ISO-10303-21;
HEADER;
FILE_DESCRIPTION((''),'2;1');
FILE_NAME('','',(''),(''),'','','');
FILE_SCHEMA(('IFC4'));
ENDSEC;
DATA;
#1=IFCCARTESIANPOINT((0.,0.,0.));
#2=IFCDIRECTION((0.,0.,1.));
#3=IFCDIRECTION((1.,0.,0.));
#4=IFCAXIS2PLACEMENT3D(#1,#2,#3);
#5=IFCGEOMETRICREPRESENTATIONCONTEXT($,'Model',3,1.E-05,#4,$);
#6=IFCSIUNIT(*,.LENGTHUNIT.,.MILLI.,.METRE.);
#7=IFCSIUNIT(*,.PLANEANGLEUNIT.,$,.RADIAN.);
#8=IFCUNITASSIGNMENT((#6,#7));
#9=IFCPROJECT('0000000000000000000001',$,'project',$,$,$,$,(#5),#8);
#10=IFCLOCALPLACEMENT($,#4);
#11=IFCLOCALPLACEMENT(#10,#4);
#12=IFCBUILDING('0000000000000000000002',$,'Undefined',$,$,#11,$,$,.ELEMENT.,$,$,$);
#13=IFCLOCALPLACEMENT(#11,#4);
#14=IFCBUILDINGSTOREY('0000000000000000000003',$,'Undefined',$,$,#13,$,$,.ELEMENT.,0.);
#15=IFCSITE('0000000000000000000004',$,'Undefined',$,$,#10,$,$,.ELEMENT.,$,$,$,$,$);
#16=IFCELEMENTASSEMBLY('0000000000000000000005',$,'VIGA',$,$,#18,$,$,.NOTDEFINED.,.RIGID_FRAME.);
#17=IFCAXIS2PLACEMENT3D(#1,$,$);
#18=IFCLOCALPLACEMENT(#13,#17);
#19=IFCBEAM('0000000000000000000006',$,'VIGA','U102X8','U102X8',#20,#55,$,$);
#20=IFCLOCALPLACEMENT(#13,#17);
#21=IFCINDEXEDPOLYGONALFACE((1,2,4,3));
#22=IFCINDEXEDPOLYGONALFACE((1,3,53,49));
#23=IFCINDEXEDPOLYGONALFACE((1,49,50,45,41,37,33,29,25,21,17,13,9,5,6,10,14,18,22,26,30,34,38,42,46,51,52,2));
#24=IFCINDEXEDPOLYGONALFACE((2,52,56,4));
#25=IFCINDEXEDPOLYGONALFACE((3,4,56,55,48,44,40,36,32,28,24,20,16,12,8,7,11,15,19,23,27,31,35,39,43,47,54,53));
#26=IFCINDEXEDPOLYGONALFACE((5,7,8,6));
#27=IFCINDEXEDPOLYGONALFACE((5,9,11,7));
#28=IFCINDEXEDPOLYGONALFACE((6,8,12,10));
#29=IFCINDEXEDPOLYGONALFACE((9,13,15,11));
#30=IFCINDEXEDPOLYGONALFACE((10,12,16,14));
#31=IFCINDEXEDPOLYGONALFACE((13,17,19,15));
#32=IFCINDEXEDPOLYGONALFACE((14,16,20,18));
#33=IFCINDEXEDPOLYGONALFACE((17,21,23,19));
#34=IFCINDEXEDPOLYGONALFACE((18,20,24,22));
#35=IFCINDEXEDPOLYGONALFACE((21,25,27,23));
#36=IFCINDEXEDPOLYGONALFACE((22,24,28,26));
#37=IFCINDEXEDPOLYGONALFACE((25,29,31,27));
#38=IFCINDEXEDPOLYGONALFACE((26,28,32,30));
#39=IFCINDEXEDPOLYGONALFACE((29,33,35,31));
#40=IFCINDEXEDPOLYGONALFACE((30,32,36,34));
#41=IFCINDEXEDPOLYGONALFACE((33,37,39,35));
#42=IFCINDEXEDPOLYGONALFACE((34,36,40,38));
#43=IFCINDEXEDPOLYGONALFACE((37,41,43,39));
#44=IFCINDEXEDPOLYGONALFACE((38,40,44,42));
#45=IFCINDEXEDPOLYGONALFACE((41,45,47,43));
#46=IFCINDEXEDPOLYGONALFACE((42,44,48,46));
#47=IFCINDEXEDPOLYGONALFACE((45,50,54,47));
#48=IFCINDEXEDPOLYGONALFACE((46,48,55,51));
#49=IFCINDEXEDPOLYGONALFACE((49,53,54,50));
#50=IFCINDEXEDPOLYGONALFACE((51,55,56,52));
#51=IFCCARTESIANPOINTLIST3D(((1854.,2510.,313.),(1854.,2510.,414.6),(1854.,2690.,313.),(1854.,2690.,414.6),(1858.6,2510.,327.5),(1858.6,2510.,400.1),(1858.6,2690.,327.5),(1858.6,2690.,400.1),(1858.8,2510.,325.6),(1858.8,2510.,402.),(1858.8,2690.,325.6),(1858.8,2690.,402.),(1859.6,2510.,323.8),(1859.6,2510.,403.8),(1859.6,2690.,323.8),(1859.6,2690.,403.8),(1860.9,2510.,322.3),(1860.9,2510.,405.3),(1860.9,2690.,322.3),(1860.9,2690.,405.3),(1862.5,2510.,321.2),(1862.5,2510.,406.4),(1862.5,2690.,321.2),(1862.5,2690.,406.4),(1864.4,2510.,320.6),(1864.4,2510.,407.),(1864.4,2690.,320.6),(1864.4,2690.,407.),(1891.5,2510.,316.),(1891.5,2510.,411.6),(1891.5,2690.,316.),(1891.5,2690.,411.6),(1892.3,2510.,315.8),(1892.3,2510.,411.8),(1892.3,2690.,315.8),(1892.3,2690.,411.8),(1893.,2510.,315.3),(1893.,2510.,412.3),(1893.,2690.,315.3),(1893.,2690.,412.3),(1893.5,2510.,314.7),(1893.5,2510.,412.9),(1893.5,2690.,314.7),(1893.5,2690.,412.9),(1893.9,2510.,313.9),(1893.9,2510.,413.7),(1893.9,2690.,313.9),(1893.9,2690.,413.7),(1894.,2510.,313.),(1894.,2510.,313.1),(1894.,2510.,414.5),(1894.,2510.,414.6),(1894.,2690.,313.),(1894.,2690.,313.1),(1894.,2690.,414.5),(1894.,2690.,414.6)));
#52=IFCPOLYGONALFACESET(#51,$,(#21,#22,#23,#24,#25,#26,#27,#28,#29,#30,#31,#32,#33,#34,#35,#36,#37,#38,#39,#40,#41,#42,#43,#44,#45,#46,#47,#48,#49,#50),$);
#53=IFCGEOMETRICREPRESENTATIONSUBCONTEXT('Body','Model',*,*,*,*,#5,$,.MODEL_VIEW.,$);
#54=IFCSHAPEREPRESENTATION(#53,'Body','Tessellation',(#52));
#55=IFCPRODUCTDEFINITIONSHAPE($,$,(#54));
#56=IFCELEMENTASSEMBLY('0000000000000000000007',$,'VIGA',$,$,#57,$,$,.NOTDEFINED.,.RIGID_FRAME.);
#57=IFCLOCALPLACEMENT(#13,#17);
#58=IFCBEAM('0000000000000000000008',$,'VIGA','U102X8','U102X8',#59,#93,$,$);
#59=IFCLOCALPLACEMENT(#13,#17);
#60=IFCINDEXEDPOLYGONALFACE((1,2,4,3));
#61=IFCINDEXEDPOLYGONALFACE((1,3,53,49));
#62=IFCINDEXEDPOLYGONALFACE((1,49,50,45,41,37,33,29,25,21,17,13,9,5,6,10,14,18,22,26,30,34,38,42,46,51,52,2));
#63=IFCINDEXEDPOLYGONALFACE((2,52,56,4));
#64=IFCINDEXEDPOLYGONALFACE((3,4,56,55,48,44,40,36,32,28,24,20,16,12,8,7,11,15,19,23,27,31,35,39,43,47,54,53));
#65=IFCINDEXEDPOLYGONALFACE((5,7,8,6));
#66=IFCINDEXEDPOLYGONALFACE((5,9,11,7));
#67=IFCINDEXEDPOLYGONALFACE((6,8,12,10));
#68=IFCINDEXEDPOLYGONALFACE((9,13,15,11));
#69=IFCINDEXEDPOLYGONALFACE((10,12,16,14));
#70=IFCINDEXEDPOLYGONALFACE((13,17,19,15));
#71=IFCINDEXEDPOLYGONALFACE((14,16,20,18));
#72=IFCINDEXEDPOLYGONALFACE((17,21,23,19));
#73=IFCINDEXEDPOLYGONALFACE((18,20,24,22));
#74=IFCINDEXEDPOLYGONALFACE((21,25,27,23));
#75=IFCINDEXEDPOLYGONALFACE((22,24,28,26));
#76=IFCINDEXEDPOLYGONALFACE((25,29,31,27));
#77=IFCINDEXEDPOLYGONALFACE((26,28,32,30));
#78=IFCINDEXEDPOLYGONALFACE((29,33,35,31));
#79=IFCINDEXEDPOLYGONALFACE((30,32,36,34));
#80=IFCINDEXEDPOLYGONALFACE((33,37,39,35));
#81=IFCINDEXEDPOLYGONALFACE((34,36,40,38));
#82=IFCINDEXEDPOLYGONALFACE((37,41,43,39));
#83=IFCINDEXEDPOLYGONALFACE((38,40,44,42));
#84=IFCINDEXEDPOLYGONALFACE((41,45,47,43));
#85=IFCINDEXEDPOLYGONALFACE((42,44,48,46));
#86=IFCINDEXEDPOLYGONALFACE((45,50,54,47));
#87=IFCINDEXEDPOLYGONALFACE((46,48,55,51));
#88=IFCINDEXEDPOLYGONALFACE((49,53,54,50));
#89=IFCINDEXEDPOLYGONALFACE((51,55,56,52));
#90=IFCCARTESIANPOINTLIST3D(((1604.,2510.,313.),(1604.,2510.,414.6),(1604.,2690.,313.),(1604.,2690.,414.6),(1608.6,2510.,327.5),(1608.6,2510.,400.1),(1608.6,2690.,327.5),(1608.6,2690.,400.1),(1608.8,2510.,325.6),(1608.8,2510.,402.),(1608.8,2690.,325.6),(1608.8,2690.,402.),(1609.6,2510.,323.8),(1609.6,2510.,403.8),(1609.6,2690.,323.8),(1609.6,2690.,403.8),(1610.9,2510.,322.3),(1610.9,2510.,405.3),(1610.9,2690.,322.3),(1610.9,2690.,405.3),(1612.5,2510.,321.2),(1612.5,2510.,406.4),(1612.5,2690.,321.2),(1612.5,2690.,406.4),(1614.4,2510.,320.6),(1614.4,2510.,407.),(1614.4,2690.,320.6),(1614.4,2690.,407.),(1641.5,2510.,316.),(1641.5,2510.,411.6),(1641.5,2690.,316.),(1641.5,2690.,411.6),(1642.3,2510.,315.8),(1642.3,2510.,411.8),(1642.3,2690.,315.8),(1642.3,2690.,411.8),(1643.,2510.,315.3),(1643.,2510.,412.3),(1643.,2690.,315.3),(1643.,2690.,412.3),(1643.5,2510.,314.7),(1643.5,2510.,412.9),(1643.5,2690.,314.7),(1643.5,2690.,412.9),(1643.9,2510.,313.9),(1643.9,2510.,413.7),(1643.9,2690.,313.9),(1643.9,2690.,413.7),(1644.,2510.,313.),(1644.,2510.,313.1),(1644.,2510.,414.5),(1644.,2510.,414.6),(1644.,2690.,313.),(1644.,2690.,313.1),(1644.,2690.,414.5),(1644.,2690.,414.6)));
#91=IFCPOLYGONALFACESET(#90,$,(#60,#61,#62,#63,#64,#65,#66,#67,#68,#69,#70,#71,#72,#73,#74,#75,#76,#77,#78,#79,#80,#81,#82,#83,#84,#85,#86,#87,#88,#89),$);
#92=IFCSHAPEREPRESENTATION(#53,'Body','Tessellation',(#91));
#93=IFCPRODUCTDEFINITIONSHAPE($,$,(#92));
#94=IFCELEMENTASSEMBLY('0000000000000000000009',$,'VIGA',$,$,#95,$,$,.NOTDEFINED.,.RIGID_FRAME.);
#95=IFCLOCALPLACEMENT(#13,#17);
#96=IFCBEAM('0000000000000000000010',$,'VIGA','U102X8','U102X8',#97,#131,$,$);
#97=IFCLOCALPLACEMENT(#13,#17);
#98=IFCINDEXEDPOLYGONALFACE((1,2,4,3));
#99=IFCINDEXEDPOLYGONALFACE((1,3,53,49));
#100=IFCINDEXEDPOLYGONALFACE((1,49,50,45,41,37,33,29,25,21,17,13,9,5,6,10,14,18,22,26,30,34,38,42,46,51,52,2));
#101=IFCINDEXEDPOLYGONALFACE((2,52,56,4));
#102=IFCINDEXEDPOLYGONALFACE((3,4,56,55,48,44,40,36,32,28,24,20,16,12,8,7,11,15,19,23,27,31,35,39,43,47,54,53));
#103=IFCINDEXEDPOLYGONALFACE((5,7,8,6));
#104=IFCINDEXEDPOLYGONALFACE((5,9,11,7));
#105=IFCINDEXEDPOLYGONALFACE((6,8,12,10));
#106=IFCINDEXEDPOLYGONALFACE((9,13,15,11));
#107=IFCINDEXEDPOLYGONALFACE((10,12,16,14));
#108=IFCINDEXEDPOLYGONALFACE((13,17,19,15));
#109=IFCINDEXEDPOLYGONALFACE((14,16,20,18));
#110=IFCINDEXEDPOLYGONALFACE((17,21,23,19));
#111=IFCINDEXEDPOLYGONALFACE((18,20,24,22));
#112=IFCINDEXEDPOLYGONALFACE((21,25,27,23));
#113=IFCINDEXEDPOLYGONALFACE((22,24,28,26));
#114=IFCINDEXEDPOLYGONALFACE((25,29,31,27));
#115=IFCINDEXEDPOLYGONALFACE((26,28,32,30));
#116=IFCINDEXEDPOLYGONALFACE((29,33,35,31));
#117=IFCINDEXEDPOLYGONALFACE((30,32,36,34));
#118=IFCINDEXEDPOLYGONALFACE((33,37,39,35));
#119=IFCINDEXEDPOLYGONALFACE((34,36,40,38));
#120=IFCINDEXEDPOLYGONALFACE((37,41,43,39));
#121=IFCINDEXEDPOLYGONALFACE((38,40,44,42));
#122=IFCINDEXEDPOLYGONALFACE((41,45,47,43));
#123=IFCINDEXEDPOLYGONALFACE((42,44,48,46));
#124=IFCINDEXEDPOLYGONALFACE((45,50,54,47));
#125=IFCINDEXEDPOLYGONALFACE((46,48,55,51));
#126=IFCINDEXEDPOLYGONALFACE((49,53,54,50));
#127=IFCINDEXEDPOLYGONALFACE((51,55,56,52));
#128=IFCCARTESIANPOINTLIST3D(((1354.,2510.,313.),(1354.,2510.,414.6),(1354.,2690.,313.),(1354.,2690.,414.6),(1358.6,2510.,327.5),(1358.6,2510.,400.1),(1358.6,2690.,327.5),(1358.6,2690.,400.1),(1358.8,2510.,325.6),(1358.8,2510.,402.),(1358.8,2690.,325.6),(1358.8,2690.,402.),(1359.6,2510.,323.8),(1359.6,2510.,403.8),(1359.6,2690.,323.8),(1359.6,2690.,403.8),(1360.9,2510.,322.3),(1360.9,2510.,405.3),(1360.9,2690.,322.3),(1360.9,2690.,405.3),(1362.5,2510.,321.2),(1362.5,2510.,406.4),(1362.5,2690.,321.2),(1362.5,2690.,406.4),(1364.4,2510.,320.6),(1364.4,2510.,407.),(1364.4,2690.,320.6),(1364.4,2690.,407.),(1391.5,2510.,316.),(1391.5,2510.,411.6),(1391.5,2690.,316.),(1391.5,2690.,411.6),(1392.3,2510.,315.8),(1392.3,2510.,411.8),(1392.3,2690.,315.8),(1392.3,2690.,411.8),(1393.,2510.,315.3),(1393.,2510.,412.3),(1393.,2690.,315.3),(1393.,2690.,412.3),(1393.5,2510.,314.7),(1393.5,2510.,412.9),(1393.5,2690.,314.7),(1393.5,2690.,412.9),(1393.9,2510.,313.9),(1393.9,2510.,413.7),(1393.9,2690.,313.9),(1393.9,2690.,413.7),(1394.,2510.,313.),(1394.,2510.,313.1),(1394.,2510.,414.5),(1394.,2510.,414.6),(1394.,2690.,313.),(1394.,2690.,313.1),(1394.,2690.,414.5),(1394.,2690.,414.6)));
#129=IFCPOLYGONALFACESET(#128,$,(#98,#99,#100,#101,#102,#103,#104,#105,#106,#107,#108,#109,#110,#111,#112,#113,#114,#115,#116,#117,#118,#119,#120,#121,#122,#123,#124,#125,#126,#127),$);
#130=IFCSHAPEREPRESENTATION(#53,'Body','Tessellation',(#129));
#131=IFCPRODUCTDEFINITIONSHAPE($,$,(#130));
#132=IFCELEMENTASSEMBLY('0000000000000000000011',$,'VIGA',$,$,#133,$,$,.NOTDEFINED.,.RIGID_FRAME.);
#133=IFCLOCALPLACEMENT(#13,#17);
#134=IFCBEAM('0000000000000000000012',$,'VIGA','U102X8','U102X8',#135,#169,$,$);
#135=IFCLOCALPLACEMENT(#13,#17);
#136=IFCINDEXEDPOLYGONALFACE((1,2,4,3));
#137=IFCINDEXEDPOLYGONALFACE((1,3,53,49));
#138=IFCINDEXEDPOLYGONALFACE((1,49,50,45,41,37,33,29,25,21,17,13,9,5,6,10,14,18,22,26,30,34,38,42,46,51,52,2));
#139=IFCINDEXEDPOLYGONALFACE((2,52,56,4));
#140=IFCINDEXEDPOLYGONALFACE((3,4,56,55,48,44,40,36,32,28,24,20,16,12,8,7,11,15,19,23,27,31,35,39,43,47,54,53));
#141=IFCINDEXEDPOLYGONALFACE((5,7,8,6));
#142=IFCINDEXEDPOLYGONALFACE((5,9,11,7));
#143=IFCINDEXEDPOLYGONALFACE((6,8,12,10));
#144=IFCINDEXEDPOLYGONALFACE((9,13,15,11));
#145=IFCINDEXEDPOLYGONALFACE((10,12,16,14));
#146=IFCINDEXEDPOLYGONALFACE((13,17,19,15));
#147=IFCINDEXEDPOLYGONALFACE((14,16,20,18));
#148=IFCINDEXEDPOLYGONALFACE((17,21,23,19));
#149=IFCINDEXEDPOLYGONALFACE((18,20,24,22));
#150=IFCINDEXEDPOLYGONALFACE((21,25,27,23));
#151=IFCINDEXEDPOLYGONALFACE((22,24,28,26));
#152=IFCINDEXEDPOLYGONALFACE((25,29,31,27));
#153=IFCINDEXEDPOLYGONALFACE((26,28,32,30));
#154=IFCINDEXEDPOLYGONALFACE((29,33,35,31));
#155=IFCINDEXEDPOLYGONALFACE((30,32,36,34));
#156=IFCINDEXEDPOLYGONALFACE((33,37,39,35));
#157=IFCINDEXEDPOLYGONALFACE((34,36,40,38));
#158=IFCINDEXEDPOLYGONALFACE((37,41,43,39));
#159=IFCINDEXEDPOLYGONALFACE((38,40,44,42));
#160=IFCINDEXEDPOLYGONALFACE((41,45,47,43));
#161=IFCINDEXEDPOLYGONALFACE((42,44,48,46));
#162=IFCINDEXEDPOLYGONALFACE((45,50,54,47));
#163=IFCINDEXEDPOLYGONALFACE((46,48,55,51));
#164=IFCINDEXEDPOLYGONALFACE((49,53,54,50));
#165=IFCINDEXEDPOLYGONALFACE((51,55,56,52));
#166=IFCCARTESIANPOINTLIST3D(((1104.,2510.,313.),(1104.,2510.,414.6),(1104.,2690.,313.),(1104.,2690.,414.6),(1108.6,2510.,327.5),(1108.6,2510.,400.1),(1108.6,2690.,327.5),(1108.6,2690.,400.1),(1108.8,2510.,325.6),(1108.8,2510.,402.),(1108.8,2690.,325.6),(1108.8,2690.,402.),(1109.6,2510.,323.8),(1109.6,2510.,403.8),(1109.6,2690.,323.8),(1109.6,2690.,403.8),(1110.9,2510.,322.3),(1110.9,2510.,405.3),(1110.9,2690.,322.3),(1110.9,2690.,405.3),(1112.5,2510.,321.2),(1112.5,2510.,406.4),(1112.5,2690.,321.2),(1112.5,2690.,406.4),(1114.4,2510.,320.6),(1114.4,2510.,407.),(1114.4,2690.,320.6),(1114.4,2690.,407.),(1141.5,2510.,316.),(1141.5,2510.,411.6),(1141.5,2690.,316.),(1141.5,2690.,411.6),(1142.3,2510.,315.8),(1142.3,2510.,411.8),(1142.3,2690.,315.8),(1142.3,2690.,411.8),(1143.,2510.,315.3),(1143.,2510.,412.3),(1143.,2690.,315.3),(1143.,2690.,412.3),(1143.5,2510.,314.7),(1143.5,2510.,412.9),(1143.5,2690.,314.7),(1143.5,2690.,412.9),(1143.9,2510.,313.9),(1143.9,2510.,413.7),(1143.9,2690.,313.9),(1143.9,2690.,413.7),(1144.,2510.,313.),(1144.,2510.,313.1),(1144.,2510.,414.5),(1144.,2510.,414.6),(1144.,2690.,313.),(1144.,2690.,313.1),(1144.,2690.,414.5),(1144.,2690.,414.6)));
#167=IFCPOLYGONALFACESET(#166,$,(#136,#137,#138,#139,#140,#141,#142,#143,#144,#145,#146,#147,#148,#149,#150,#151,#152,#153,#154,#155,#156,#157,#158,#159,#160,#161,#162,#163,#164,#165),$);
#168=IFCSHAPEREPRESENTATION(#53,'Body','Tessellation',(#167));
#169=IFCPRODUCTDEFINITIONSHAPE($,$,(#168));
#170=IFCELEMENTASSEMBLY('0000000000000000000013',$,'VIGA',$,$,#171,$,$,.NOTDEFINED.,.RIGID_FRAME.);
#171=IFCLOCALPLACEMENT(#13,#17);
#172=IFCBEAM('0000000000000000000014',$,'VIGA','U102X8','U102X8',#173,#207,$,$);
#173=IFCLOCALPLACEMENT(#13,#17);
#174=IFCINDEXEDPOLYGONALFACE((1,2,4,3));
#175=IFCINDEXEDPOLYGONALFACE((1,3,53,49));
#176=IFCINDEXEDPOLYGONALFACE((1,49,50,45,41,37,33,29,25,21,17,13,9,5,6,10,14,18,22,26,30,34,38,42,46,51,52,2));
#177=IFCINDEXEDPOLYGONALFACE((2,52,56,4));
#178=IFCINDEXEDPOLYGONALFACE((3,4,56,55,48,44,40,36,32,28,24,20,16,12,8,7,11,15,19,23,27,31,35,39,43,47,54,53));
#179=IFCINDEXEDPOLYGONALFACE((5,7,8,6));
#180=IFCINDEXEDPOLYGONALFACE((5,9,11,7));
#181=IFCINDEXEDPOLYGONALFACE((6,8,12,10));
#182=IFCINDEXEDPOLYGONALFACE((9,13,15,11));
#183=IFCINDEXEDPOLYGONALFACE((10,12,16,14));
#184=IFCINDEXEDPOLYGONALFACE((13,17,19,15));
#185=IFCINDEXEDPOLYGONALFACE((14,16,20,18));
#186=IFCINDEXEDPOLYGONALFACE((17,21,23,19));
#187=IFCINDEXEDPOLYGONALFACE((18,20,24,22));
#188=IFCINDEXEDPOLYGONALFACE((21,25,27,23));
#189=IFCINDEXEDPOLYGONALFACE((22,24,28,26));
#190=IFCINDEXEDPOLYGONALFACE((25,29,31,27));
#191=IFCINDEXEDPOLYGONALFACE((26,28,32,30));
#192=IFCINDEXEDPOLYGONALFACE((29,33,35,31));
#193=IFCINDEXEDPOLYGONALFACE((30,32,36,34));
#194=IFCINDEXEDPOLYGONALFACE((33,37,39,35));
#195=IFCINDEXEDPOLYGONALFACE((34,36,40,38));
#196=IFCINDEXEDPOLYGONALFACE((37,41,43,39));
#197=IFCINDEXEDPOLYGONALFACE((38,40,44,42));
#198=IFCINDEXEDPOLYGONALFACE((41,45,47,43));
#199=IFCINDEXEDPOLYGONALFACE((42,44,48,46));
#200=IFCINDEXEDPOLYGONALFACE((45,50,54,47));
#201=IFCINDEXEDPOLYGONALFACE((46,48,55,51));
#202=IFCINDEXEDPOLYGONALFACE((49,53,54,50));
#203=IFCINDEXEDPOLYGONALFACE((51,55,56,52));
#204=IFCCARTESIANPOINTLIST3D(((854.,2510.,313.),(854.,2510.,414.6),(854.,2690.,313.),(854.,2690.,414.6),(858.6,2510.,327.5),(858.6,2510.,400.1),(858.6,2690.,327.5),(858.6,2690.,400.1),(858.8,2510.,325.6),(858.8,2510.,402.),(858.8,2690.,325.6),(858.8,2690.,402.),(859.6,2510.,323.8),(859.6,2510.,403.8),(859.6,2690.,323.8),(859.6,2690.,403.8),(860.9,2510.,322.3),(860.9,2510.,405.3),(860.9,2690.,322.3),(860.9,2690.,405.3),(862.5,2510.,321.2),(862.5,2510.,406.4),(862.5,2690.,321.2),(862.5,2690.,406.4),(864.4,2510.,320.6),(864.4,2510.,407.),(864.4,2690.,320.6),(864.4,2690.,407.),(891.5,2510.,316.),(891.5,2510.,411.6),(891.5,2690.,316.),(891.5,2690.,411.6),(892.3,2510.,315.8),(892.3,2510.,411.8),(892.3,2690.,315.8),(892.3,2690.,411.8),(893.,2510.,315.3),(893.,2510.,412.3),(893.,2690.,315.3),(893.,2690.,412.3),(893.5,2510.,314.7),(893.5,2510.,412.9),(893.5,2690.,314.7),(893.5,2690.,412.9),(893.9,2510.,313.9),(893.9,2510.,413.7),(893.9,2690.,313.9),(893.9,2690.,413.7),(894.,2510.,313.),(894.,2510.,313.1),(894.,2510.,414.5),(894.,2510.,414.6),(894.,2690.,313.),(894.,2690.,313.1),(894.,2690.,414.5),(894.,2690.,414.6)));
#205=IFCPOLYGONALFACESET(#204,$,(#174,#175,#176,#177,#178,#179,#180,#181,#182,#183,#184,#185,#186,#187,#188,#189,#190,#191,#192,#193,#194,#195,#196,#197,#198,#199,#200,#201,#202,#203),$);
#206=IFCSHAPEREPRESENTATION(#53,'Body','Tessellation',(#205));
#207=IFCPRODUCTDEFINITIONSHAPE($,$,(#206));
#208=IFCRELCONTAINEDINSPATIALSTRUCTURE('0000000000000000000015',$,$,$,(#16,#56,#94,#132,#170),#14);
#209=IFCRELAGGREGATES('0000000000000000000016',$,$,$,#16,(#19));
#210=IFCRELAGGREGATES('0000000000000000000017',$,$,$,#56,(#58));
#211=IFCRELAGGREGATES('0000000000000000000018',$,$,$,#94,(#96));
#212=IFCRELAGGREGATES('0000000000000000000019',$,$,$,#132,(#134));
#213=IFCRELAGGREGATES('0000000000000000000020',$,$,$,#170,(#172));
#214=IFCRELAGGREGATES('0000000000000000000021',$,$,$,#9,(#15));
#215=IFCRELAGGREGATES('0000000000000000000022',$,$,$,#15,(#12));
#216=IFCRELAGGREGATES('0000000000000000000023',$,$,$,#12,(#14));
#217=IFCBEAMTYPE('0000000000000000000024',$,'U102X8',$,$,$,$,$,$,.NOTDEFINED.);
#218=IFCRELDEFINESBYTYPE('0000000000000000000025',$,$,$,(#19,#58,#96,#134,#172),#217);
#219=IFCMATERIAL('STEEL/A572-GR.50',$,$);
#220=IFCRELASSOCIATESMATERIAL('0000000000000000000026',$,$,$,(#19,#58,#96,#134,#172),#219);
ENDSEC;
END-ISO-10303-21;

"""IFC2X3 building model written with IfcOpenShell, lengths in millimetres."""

from ifc_helpers import new_model, si_unit, frame, origin_with_axes, origin_2d_with_axis, place, context, subcontext, project, spatial, u_section, extrude, material, type_object, element, aggregate, save


model = new_model("IFC2X3")

# Units and contexts
model_context = context("Model", 3, precision=1e-05, world=origin_with_axes())
body_context = subcontext(model_context, "Body", "Model", "MODEL_VIEW")
ifc_project = project(units=[si_unit("LENGTHUNIT", "METRE", prefix="MILLI"), si_unit("PLANEANGLEUNIT", "RADIAN")], contexts=[model_context])

# Site, building, storey
site_placement = place(None, origin_with_axes())
site = spatial("IfcSite", under=ifc_project, at=site_placement, Name="Undefined", CompositionType="ELEMENT")
building_placement = place(site_placement, origin_with_axes())
building = spatial("IfcBuilding", under=site, at=building_placement, Name="Undefined", CompositionType="ELEMENT")
storey_placement = place(building_placement, origin_with_axes())
storey = spatial("IfcBuildingStorey", under=building, at=storey_placement, Name="Undefined", CompositionType="ELEMENT", Elevation=0.0)

# Element assemblies, beams
ifc_material_1 = material(Name="STEEL/A572-GR.50")
beam_type_1 = type_object("IfcBeamType", Name="U102X8", PredefinedType="NOTDEFINED")
assembly_1_placement = place(storey_placement, origin_with_axes())
assembly_1 = element("IfcElementAssembly", 1, at=assembly_1_placement, inside=storey, Name="VIGA", AssemblyPlace="NOTDEFINED", PredefinedType="RIGID_FRAME")
beam_1_placement = place(assembly_1_placement, frame((1874.0, 2510.0, 363.8), z_axis=(0.0, 0.0, 1.0), x_axis=(0.0, 1.0, 0.0)))
beam_1 = element("IfcBeam", 2, at=beam_1_placement, type_object=beam_type_1, material=ifc_material_1, Name="VIGA", Description="U102X8", ObjectType="U102X8", context=body_context, shape_type="SweptSolid", body=[
    extrude(u_section(Depth=101.6, FlangeWidth=40.0, WebThickness=4.6, FlangeThickness=6.0, FilletRadius=7.0, EdgeRadius=3.0, FlangeSlope=0.16839, at=origin_2d_with_axis()), frame((180.0, 0.0, 0.0), z_axis=(-1.0, 0.0, 0.0), x_axis=(0.0, -1.0, 0.0)), (0.0, 0.0, 1.0), 180.0),
])
aggregate(assembly_1, [beam_1])
assembly_2_placement = place(storey_placement, origin_with_axes())
assembly_2 = element("IfcElementAssembly", 3, at=assembly_2_placement, inside=storey, Name="VIGA", AssemblyPlace="NOTDEFINED", PredefinedType="RIGID_FRAME")
beam_2_placement = place(assembly_2_placement, frame((1624.0, 2510.0, 363.8), z_axis=(0.0, 0.0, 1.0), x_axis=(0.0, 1.0, 0.0)))
beam_2 = element("IfcBeam", 4, at=beam_2_placement, type_object=beam_type_1, material=ifc_material_1, Name="VIGA", Description="U102X8", ObjectType="U102X8", context=body_context, shape_type="SweptSolid", body=[
    extrude(u_section(Depth=101.6, FlangeWidth=40.0, WebThickness=4.6, FlangeThickness=6.0, FilletRadius=7.0, EdgeRadius=3.0, FlangeSlope=0.16839, at=origin_2d_with_axis()), frame((180.0, 0.0, 0.0), z_axis=(-1.0, 0.0, 0.0), x_axis=(0.0, -1.0, 0.0)), (0.0, 0.0, 1.0), 180.0),
])
aggregate(assembly_2, [beam_2])
assembly_3_placement = place(storey_placement, origin_with_axes())
assembly_3 = element("IfcElementAssembly", 5, at=assembly_3_placement, inside=storey, Name="VIGA", AssemblyPlace="NOTDEFINED", PredefinedType="RIGID_FRAME")
beam_3_placement = place(assembly_3_placement, frame((1374.0, 2510.0, 363.8), z_axis=(0.0, 0.0, 1.0), x_axis=(0.0, 1.0, 0.0)))
beam_3 = element("IfcBeam", 6, at=beam_3_placement, type_object=beam_type_1, material=ifc_material_1, Name="VIGA", Description="U102X8", ObjectType="U102X8", context=body_context, shape_type="SweptSolid", body=[
    extrude(u_section(Depth=101.6, FlangeWidth=40.0, WebThickness=4.6, FlangeThickness=6.0, FilletRadius=7.0, EdgeRadius=3.0, FlangeSlope=0.16839, at=origin_2d_with_axis()), frame((180.0, 0.0, 0.0), z_axis=(-1.0, 0.0, 0.0), x_axis=(0.0, -1.0, 0.0)), (0.0, 0.0, 1.0), 180.0),
])
aggregate(assembly_3, [beam_3])
assembly_4_placement = place(storey_placement, origin_with_axes())
assembly_4 = element("IfcElementAssembly", 7, at=assembly_4_placement, inside=storey, Name="VIGA", AssemblyPlace="NOTDEFINED", PredefinedType="RIGID_FRAME")
beam_4_placement = place(assembly_4_placement, frame((1124.0, 2510.0, 363.8), z_axis=(0.0, 0.0, 1.0), x_axis=(0.0, 1.0, 0.0)))
beam_4 = element("IfcBeam", 8, at=beam_4_placement, type_object=beam_type_1, material=ifc_material_1, Name="VIGA", Description="U102X8", ObjectType="U102X8", context=body_context, shape_type="SweptSolid", body=[
    extrude(u_section(Depth=101.6, FlangeWidth=40.0, WebThickness=4.6, FlangeThickness=6.0, FilletRadius=7.0, EdgeRadius=3.0, FlangeSlope=0.16839, at=origin_2d_with_axis()), frame((180.0, 0.0, 0.0), z_axis=(-1.0, 0.0, 0.0), x_axis=(0.0, -1.0, 0.0)), (0.0, 0.0, 1.0), 180.0),
])
aggregate(assembly_4, [beam_4])
assembly_5_placement = place(storey_placement, origin_with_axes())
assembly_5 = element("IfcElementAssembly", 9, at=assembly_5_placement, inside=storey, Name="VIGA", AssemblyPlace="NOTDEFINED", PredefinedType="RIGID_FRAME")
beam_5_placement = place(assembly_5_placement, frame((874.0, 2510.0, 363.8), z_axis=(0.0, 0.0, 1.0), x_axis=(0.0, 1.0, 0.0)))
beam_5 = element("IfcBeam", 10, at=beam_5_placement, type_object=beam_type_1, material=ifc_material_1, Name="VIGA", Description="U102X8", ObjectType="U102X8", context=body_context, shape_type="SweptSolid", body=[
    extrude(u_section(Depth=101.6, FlangeWidth=40.0, WebThickness=4.6, FlangeThickness=6.0, FilletRadius=7.0, EdgeRadius=3.0, FlangeSlope=0.16839, at=origin_2d_with_axis()), frame((180.0, 0.0, 0.0), z_axis=(-1.0, 0.0, 0.0), x_axis=(0.0, -1.0, 0.0)), (0.0, 0.0, 1.0), 180.0),
])
aggregate(assembly_5, [beam_5])

save(model, "model.ifc")
